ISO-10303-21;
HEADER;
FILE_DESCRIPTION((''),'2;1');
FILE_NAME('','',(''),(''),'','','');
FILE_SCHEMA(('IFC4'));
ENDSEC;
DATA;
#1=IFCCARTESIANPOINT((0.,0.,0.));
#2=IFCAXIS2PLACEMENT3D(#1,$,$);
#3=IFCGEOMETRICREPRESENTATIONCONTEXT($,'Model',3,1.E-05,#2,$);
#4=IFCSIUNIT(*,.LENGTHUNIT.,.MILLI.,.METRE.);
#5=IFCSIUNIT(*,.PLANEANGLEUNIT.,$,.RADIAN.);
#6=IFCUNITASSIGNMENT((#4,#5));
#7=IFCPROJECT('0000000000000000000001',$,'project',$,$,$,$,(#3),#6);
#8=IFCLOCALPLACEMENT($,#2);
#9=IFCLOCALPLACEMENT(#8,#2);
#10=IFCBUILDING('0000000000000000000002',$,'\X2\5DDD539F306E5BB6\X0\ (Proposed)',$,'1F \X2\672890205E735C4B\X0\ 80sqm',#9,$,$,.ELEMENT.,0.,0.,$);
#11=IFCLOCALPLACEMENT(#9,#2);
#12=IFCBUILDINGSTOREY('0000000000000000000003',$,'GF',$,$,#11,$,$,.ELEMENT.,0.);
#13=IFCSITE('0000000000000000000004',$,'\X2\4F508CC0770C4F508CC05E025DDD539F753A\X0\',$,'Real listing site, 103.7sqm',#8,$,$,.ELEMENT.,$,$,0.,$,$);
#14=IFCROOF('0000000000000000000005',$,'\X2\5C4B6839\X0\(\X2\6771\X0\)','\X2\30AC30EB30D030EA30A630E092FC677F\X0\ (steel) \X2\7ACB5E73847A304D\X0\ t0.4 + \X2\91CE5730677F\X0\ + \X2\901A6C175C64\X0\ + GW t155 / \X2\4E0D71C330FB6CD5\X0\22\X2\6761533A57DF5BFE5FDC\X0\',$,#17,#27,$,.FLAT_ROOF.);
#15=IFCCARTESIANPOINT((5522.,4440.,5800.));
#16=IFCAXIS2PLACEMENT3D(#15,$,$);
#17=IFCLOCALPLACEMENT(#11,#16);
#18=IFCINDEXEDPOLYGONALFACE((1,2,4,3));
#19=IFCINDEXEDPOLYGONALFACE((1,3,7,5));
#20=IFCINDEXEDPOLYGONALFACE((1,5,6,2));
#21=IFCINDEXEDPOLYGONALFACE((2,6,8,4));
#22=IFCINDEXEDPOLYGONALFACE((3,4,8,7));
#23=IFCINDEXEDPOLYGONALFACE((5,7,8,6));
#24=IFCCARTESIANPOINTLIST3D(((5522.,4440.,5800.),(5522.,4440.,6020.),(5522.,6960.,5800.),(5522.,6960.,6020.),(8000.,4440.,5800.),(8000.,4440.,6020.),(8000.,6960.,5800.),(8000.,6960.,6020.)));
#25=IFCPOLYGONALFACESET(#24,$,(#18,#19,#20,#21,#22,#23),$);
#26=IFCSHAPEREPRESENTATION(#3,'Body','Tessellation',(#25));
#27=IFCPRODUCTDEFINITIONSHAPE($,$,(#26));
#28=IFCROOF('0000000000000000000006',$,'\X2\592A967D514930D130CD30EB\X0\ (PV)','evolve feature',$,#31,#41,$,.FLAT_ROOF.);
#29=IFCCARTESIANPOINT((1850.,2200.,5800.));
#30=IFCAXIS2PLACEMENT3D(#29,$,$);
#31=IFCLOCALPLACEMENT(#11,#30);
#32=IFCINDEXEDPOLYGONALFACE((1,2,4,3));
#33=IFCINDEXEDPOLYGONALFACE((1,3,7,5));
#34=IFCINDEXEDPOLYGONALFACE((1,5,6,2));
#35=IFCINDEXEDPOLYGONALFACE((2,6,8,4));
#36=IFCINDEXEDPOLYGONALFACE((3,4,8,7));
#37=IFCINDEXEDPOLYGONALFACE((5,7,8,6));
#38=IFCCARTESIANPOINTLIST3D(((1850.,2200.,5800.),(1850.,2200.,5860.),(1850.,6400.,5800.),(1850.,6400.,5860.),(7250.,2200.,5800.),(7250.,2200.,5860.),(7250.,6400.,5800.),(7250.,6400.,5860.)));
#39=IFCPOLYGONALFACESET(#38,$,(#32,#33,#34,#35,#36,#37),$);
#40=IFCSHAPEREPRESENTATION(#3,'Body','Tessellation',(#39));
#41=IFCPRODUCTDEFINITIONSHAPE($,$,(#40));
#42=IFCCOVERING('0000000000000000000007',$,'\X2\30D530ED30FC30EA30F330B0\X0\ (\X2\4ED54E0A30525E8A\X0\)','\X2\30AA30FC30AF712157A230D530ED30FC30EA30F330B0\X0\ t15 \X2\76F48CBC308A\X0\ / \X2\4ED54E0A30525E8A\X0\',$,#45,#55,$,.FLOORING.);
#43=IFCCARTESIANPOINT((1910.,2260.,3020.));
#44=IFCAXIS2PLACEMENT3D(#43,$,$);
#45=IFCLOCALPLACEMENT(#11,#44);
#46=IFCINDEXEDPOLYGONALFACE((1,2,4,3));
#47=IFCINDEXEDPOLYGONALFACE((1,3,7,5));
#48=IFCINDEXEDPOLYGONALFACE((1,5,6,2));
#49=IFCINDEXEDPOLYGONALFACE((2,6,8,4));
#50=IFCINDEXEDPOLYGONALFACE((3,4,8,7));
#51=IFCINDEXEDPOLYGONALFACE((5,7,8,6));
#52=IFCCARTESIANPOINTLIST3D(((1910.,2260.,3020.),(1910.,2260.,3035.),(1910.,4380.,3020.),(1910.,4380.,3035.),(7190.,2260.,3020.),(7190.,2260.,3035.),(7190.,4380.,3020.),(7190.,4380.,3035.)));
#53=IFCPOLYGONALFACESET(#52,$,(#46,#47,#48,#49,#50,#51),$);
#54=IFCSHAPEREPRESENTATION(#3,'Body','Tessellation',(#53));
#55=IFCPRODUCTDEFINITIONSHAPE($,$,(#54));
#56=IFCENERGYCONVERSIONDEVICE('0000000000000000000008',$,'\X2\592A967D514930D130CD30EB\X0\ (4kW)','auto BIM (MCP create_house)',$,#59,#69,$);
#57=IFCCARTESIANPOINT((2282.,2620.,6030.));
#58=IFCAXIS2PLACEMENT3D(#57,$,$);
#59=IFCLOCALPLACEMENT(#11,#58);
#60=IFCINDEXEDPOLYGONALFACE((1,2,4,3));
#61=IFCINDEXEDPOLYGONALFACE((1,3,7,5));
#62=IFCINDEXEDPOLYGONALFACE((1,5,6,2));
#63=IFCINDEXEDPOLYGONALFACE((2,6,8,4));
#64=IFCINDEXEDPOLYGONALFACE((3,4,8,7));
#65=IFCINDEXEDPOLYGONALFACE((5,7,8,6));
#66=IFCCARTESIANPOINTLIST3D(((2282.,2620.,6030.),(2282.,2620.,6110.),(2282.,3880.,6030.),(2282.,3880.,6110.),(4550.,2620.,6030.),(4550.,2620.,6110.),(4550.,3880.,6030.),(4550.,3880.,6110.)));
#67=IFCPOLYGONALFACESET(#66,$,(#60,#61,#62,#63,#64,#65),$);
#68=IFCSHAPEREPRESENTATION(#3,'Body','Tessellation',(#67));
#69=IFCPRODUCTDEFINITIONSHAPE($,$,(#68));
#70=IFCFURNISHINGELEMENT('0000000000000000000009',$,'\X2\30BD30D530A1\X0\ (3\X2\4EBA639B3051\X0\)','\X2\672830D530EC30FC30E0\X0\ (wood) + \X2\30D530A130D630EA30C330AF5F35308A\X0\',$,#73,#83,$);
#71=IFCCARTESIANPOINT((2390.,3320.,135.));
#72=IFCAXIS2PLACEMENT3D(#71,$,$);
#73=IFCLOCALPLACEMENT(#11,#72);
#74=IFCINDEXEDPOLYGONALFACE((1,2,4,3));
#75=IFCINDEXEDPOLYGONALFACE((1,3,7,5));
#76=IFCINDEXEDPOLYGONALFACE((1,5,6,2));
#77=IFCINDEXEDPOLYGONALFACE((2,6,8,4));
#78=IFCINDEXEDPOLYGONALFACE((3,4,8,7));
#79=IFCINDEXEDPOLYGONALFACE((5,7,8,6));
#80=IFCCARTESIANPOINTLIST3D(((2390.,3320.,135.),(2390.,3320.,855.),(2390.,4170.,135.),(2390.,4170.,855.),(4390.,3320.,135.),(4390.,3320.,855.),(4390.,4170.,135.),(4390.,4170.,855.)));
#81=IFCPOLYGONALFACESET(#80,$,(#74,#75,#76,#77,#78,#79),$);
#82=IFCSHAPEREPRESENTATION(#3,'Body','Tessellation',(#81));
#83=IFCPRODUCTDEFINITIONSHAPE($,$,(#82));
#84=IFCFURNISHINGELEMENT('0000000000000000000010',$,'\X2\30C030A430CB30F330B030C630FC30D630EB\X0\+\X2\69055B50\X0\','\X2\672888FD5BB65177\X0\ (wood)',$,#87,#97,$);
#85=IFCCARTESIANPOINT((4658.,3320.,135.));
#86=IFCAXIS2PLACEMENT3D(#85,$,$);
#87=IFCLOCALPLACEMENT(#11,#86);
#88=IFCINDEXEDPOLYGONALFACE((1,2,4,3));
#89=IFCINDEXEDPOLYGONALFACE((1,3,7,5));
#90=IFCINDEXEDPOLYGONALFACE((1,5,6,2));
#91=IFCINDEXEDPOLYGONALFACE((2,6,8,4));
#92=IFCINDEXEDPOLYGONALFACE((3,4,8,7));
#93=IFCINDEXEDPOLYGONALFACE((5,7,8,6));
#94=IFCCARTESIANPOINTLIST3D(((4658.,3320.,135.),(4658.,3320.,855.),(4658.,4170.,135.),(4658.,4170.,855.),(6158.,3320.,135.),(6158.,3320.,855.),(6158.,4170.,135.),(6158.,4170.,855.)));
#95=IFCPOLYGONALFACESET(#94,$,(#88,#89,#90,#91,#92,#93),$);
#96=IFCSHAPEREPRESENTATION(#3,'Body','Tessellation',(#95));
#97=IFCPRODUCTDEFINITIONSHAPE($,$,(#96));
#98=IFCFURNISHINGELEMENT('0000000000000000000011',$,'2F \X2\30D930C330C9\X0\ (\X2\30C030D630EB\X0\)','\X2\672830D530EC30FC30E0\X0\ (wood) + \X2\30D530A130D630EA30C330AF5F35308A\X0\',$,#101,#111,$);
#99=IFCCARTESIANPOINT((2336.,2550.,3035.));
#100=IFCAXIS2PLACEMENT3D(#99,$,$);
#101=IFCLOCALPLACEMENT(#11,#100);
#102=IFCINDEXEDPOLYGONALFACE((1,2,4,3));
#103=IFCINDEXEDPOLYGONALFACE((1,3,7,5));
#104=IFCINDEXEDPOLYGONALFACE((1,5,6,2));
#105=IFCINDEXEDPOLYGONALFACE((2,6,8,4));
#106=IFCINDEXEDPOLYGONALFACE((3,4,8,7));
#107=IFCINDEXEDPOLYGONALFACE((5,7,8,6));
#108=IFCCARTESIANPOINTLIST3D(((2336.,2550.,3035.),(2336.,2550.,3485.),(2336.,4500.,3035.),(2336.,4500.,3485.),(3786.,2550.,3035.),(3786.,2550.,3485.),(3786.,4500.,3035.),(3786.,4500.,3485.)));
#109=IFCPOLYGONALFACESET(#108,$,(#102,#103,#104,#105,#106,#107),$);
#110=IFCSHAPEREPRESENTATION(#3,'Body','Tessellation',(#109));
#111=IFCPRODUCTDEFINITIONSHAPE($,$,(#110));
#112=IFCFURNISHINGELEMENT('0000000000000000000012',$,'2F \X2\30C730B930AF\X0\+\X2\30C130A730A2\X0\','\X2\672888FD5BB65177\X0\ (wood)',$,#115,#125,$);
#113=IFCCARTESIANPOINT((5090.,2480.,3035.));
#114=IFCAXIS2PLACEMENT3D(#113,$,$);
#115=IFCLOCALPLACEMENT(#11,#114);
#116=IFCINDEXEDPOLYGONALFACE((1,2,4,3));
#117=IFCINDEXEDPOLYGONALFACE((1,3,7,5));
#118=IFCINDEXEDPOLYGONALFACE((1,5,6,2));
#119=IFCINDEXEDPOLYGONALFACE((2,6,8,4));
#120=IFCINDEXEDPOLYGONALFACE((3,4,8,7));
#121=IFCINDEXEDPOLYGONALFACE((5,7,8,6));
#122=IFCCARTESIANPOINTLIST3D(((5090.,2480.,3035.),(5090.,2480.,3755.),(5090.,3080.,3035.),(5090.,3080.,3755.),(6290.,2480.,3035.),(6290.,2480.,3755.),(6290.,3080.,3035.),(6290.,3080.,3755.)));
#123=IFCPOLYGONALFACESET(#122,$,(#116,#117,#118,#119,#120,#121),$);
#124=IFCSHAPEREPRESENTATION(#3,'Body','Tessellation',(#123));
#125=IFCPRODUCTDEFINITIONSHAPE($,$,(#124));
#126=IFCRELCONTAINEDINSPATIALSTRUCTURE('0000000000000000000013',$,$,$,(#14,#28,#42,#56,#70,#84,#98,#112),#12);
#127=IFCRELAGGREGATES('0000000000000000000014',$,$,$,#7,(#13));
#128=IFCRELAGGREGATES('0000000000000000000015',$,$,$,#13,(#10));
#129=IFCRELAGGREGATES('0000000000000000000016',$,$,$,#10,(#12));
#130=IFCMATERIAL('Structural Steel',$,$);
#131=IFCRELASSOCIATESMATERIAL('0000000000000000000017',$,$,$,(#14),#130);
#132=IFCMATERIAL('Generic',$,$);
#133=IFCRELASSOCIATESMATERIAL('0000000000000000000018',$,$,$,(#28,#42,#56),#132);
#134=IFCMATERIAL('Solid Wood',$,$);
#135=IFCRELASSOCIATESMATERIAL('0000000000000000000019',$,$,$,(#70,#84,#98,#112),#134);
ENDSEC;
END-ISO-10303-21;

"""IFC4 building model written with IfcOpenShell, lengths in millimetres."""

from ifc_helpers import new_model, si_unit, frame, frame_2d, origin, place, context, project, spatial, rectangle, extrude, material, element, save


model = new_model("IFC4")

# Units and contexts
model_context = context("Model", 3, precision=1e-05, world=origin())
ifc_project = project(units=[si_unit("LENGTHUNIT", "METRE", prefix="MILLI"), si_unit("PLANEANGLEUNIT", "RADIAN")], contexts=[model_context])

# Site, building, storey
site_placement = place(None, origin())
site = spatial("IfcSite", under=ifc_project, at=site_placement, Name="佐賀県佐賀市川原町", ObjectType="Real listing site, 103.7sqm", CompositionType="ELEMENT", RefElevation=0.0)
building_placement = place(site_placement, origin())
building = spatial("IfcBuilding", under=site, at=building_placement, Name="川原の家 (Proposed)", ObjectType="1F 木造平屋 80sqm", CompositionType="ELEMENT", ElevationOfRefHeight=0.0, ElevationOfTerrain=0.0)
storey_placement = place(building_placement, origin())
storey = spatial("IfcBuildingStorey", under=building, at=storey_placement, Name="GF", CompositionType="ELEMENT", Elevation=0.0)

# Shared definitions
ifc_material_1 = material(Name="Solid Wood")

# Roofs
ifc_material_2 = material(Name="Structural Steel")
roof_1_placement = place(storey_placement, frame((5522.0, 4440.0, 5800.0)))
element("IfcRoof", 1, at=roof_1_placement, inside=storey, material=ifc_material_2, Name="屋根(東)", Description="ガルバリウム鋼板 (steel) 立平葺き t0.4 + 野地板 + 通気層 + GW t155 / 不燃・法22条区域対応", PredefinedType="FLAT_ROOF", context=model_context, shape_type="SweptSolid", body=[
    extrude(rectangle(XDim=2478.0, YDim=2520.0, at=frame_2d((1239.0, 1260.0))), frame((5522.0, 4440.0, 5800.0)), (0.0, 0.0, 1.0), 220.0),
])
ifc_material_3 = material(Name="Generic")
roof_2_placement = place(storey_placement, frame((1850.0, 2200.0, 5800.0)))
element("IfcRoof", 2, at=roof_2_placement, inside=storey, material=ifc_material_3, Name="太陽光パネル (PV)", Description="evolve feature", PredefinedType="FLAT_ROOF", context=model_context, shape_type="SweptSolid", body=[
    extrude(rectangle(XDim=5400.0, YDim=4200.0, at=frame_2d((2700.0, 2100.0))), frame((1850.0, 2200.0, 5800.0)), (0.0, 0.0, 1.0), 60.0),
])

# Covering
covering_placement = place(storey_placement, frame((1910.0, 2260.0, 3020.0)))
element("IfcCovering", 3, at=covering_placement, inside=storey, material=ifc_material_3, Name="フローリング (仕上げ床)", Description="オーク無垢フローリング t15 直貼り / 仕上げ床", PredefinedType="FLOORING", context=model_context, shape_type="SweptSolid", body=[
    extrude(rectangle(XDim=5280.0, YDim=2120.0, at=frame_2d((2640.0, 1060.0))), frame((1910.0, 2260.0, 3020.0)), (0.0, 0.0, 1.0), 15.0),
])

# Energy conversion device
energy_conversion_device_placement = place(storey_placement, frame((2282.0, 2620.0, 6030.0)))
element("IfcEnergyConversionDevice", 4, at=energy_conversion_device_placement, inside=storey, material=ifc_material_3, Name="太陽光パネル (4kW)", Description="auto BIM (MCP create_house)", context=model_context, shape_type="SweptSolid", body=[
    extrude(rectangle(XDim=2268.0, YDim=1260.0, at=frame_2d((1134.0, 630.0))), frame((2282.0, 2620.0, 6030.0)), (0.0, 0.0, 1.0), 80.0),
])

# Furnishing elements
furnishing_1_placement = place(storey_placement, frame((2390.0, 3320.0, 135.0)))
element("IfcFurnishingElement", 5, at=furnishing_1_placement, inside=storey, material=ifc_material_1, Name="ソファ (3人掛け)", Description="木フレーム (wood) + ファブリック張り", context=model_context, shape_type="SweptSolid", body=[
    extrude(rectangle(XDim=2000.0, YDim=850.0, at=frame_2d((1000.0, 425.0))), frame((2390.0, 3320.0, 135.0)), (0.0, 0.0, 1.0), 720.0),
])
furnishing_2_placement = place(storey_placement, frame((4658.0, 3320.0, 135.0)))
element("IfcFurnishingElement", 6, at=furnishing_2_placement, inside=storey, material=ifc_material_1, Name="ダイニングテーブル+椅子", Description="木製家具 (wood)", context=model_context, shape_type="SweptSolid", body=[
    extrude(rectangle(XDim=1500.0, YDim=850.0, at=frame_2d((750.0, 425.0))), frame((4658.0, 3320.0, 135.0)), (0.0, 0.0, 1.0), 720.0),
])
furnishing_3_placement = place(storey_placement, frame((2336.0, 2550.0, 3035.0)))
element("IfcFurnishingElement", 7, at=furnishing_3_placement, inside=storey, material=ifc_material_1, Name="2F ベッド (ダブル)", Description="木フレーム (wood) + ファブリック張り", context=model_context, shape_type="SweptSolid", body=[
    extrude(rectangle(XDim=1450.0, YDim=1950.0, at=frame_2d((725.0, 975.0))), frame((2336.0, 2550.0, 3035.0)), (0.0, 0.0, 1.0), 450.0),
])
furnishing_4_placement = place(storey_placement, frame((5090.0, 2480.0, 3035.0)))
element("IfcFurnishingElement", 8, at=furnishing_4_placement, inside=storey, material=ifc_material_1, Name="2F デスク+チェア", Description="木製家具 (wood)", context=model_context, shape_type="SweptSolid", body=[
    extrude(rectangle(XDim=1200.0, YDim=600.0, at=frame_2d((600.0, 300.0))), frame((5090.0, 2480.0, 3035.0)), (0.0, 0.0, 1.0), 720.0),
])

save(model, "model.ifc")
